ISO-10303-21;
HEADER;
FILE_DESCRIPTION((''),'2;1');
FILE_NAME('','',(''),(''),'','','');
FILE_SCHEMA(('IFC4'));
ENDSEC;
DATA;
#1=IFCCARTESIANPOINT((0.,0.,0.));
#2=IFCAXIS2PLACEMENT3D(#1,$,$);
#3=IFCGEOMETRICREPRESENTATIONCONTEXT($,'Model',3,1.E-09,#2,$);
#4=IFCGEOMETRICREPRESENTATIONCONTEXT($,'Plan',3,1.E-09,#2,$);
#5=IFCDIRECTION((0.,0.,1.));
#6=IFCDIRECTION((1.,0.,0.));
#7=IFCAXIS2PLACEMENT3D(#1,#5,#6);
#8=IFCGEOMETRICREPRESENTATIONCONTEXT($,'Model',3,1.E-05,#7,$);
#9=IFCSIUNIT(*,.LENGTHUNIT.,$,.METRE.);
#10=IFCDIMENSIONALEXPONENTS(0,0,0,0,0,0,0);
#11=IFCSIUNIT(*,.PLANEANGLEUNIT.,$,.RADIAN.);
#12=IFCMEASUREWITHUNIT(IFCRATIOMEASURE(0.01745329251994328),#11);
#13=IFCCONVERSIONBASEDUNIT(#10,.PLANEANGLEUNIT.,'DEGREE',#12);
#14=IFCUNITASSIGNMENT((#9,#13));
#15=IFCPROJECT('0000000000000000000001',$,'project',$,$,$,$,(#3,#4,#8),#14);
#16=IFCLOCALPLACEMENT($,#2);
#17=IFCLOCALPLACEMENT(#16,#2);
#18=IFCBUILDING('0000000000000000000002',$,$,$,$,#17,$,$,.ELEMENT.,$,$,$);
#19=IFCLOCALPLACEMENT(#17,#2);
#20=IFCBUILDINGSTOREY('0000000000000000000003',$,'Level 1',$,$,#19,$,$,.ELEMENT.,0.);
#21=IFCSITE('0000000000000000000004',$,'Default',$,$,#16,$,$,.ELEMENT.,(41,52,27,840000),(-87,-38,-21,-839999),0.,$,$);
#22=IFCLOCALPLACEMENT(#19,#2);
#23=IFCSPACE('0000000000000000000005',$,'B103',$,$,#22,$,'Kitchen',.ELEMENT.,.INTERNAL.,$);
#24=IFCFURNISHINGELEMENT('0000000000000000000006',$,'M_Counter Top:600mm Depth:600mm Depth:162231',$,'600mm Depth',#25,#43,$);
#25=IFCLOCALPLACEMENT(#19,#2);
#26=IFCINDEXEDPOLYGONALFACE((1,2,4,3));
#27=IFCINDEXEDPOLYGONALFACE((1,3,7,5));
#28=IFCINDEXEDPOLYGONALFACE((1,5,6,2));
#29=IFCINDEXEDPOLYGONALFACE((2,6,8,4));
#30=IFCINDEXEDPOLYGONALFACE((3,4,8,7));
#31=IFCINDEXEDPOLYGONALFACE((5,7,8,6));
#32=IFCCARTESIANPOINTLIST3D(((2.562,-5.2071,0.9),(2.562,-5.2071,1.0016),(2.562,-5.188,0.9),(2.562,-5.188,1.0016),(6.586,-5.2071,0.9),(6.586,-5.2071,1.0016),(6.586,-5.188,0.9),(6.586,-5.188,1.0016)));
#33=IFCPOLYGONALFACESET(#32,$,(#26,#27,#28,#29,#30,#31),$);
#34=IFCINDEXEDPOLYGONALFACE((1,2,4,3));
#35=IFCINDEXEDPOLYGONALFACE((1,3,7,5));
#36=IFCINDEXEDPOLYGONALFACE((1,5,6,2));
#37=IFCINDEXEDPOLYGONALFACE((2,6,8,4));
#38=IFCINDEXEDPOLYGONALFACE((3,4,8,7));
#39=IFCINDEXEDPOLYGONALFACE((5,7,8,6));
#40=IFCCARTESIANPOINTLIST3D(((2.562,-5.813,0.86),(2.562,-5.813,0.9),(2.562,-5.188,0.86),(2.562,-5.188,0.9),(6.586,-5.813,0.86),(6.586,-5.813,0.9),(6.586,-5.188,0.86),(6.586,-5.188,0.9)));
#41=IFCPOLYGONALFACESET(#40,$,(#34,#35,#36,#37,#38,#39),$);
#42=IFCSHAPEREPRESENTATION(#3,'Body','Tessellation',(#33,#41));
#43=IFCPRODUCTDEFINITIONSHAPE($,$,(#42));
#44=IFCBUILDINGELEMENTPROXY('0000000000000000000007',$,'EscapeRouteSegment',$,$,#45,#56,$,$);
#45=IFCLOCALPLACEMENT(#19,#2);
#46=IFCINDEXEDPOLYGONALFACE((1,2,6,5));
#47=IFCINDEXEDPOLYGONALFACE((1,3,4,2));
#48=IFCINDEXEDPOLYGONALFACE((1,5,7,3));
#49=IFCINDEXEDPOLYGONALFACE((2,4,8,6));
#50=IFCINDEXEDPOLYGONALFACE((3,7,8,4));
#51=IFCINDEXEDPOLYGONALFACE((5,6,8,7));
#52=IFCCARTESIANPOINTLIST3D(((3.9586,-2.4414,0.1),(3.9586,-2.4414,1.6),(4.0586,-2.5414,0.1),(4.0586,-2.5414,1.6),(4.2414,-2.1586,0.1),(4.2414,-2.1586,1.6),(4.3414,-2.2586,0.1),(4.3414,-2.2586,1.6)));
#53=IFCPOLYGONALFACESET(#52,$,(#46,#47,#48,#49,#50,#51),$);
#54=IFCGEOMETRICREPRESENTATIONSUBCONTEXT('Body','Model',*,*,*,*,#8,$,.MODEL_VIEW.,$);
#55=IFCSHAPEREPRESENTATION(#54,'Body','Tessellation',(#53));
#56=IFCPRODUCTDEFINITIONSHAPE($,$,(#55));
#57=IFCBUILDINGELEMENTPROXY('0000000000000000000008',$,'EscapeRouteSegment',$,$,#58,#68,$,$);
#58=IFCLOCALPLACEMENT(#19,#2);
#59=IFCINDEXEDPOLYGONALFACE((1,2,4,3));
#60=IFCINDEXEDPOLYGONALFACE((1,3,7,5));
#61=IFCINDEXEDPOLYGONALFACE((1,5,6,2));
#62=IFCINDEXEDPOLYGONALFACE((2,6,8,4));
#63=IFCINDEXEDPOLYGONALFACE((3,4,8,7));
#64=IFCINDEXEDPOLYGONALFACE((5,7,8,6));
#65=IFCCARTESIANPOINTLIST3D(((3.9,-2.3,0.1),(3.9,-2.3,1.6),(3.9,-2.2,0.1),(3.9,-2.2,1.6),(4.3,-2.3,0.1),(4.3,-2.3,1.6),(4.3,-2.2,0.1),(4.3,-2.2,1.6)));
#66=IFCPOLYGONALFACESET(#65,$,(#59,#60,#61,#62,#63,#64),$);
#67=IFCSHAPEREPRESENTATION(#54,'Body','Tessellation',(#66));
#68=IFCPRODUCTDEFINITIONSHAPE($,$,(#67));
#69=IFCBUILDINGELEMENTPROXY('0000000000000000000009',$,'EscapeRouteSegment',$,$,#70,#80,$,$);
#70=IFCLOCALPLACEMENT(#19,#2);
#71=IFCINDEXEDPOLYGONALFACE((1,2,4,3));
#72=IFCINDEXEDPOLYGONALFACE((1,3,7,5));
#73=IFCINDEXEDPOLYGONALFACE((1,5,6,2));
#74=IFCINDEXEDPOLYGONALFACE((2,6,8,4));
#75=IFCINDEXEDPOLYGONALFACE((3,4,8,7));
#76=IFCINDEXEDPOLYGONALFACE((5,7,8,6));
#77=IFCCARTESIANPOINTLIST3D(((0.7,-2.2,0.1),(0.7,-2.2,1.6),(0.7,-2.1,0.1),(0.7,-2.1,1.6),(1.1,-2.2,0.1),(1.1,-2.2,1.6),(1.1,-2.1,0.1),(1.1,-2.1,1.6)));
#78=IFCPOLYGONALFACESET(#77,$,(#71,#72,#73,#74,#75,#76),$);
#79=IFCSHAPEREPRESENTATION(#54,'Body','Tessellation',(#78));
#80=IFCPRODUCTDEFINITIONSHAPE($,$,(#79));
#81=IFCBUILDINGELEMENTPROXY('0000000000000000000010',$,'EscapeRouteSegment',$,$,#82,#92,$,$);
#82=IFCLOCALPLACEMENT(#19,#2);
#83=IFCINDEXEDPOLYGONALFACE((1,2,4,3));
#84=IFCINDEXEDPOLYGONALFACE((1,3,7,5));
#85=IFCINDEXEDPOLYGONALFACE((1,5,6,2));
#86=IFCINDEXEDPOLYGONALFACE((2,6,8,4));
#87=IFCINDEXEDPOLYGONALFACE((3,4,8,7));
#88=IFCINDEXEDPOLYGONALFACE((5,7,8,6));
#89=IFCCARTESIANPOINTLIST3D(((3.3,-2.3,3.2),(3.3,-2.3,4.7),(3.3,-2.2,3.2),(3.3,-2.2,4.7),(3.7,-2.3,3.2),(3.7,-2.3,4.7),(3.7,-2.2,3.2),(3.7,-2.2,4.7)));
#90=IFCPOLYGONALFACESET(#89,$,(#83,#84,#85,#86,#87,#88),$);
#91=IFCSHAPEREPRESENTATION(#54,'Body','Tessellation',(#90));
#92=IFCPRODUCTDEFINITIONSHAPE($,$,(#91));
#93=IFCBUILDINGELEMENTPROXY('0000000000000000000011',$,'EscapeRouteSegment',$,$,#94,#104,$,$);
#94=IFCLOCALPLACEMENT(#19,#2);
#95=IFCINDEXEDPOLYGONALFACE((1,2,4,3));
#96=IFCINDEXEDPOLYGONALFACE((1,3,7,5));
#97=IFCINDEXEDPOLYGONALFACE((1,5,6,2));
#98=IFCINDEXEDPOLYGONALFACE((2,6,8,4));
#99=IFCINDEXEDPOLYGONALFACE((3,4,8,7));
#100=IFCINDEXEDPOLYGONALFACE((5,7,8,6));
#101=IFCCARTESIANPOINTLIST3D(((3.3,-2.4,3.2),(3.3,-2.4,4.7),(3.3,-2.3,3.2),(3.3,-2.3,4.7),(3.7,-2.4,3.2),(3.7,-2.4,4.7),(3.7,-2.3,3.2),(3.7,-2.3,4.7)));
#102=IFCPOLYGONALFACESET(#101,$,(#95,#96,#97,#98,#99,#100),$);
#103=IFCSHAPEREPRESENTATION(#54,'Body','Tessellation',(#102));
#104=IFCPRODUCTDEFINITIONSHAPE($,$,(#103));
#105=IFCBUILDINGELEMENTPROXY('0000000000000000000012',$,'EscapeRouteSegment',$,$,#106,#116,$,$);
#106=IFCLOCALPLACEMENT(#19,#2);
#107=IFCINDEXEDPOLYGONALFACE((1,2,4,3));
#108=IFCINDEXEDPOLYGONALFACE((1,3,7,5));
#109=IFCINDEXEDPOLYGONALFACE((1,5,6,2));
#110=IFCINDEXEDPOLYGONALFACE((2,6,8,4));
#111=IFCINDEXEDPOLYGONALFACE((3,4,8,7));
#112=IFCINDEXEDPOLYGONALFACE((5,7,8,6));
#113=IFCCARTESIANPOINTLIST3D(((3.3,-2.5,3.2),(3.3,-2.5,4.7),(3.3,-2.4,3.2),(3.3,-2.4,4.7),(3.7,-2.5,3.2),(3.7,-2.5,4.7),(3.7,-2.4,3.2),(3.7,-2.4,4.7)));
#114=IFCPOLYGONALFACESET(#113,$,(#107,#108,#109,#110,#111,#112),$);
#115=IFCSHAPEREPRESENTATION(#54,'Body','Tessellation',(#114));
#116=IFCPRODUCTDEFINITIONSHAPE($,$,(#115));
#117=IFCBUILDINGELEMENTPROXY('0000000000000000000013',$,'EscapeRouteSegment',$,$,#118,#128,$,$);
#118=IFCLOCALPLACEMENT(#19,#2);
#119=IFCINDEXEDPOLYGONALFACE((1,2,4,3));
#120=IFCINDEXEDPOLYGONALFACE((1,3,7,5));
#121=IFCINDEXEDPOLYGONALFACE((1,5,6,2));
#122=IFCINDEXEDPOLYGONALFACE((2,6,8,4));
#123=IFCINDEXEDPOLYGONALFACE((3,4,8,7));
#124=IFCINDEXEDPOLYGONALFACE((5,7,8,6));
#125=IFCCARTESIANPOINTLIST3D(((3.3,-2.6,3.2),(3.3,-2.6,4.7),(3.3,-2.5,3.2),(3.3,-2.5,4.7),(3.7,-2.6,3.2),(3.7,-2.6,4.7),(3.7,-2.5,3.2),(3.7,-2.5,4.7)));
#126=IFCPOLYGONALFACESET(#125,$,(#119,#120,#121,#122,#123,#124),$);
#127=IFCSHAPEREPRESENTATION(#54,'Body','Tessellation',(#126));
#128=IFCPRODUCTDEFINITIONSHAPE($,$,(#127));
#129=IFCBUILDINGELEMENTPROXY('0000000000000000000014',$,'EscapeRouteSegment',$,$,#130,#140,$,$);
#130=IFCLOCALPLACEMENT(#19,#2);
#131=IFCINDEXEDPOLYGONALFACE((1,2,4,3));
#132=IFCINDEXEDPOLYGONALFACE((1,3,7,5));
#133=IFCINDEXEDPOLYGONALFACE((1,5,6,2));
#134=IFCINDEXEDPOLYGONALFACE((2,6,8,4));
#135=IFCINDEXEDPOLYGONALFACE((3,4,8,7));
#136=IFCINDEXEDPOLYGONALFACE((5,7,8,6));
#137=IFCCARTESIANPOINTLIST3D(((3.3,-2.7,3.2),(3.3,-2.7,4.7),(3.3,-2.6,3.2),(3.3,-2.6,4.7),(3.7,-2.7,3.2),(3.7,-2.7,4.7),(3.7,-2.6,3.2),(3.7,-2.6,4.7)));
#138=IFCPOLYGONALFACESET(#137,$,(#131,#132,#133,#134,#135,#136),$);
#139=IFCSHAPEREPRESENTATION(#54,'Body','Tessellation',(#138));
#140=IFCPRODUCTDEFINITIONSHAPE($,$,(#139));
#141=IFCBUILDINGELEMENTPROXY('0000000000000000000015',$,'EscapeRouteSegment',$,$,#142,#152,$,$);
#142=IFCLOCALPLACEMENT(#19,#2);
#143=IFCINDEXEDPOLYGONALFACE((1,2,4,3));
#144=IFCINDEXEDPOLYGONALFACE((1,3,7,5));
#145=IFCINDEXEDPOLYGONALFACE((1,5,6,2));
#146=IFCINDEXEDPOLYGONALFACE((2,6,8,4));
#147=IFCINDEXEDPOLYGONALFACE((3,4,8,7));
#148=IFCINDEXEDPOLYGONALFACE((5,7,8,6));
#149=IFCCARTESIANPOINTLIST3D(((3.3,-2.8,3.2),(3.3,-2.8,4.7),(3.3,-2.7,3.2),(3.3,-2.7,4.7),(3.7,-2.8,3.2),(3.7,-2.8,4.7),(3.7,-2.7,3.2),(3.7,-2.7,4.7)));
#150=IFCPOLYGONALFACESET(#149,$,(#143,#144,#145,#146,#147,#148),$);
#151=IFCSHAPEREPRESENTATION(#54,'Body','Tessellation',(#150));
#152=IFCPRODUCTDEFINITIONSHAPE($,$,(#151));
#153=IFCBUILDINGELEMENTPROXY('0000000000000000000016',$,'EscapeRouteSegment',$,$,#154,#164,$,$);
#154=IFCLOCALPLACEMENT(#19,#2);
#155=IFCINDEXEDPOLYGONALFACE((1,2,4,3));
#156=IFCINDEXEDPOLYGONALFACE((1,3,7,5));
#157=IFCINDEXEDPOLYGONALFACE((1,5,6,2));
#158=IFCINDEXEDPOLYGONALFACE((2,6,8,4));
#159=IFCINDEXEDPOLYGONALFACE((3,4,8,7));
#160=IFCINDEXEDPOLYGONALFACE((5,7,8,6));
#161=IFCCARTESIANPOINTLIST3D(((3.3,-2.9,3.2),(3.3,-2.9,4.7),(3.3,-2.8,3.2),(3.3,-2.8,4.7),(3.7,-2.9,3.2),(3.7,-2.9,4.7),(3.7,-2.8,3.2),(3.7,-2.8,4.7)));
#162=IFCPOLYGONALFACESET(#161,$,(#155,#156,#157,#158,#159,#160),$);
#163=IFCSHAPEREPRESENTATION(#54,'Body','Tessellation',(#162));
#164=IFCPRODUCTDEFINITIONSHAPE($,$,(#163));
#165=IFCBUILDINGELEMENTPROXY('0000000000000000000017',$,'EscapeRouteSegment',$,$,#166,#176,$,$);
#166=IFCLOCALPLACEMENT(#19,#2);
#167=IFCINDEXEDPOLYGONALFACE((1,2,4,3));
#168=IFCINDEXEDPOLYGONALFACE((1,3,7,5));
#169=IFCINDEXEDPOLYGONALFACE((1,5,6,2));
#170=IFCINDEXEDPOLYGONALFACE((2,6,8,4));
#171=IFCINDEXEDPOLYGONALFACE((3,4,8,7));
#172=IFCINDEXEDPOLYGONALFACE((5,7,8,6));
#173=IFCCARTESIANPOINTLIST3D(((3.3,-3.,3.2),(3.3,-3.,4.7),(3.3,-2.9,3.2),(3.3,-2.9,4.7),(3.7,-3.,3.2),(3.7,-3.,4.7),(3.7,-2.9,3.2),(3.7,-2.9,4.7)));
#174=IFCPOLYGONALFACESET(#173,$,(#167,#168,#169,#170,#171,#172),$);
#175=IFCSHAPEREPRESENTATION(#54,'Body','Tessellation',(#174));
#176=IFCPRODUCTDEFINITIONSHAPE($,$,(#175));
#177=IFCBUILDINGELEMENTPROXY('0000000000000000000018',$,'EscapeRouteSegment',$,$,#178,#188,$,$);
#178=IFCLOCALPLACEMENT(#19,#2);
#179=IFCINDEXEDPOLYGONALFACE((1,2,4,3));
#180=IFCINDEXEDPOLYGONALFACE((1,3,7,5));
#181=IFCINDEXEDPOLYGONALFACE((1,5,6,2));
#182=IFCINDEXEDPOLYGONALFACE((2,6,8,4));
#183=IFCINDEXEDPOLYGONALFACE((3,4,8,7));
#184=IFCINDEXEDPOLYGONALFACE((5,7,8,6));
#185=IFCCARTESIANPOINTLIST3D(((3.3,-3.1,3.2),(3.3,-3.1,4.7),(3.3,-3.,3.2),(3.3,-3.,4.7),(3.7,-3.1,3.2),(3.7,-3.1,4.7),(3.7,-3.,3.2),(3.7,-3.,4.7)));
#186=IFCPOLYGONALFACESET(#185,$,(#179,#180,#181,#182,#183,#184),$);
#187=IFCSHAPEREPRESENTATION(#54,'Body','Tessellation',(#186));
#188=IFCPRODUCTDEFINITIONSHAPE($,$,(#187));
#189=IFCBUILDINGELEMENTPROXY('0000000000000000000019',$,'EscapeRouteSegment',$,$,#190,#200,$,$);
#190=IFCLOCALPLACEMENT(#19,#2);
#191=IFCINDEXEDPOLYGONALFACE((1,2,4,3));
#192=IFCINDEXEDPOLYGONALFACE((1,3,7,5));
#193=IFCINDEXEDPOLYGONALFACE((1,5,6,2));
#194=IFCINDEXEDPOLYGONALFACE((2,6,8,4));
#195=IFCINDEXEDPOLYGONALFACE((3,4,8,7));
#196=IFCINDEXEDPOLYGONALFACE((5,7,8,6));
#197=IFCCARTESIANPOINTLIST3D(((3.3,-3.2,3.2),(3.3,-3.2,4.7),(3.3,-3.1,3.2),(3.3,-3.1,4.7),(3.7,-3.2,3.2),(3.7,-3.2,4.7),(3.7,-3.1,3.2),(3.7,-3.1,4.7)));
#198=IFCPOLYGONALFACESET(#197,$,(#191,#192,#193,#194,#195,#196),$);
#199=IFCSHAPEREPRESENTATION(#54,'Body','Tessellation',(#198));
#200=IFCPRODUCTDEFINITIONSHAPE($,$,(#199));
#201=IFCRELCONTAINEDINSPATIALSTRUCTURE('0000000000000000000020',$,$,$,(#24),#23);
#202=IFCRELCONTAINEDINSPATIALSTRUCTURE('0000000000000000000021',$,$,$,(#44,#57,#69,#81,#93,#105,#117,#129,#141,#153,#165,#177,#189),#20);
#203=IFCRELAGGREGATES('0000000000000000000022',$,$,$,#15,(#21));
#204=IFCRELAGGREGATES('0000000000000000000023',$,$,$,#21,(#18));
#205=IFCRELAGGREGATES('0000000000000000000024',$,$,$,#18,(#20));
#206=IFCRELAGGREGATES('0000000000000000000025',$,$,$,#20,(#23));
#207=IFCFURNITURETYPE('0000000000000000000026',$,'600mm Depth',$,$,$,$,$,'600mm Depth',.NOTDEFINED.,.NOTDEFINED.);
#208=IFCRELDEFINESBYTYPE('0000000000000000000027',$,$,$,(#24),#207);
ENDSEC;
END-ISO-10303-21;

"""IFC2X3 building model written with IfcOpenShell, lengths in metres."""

from ifc_helpers import new_model, entity, si_unit, converted_unit, frame, origin, origin_with_axes, origin_2d_with_axis, place, context, subcontext, project, spatial, polyline, rectangle, outline, extrude, source, transform, mapped, type_object, type_shapes, element, save


model = new_model("IFC2X3")

# Units and contexts
model_context_1 = context("Model", 3, precision=1e-09, world=origin())
plan_context = context("Plan", 3, precision=1e-09, world=origin())
model_context_2 = context("Model", 3, precision=1e-05, world=origin_with_axes())
body_context = subcontext(model_context_2, "Body", "Model", "MODEL_VIEW")
ifc_project = project(units=[si_unit("LENGTHUNIT", "METRE"), converted_unit("PLANEANGLEUNIT", "DEGREE", entity("IfcRatioMeasure", 0.01745329251994328), si_unit("PLANEANGLEUNIT", "RADIAN"), dimensions=[0, 0, 0, 0, 0, 0, 0])], contexts=[model_context_1, plan_context, model_context_2])

# Site, building, storey, space
site_placement = place(None, origin())
site = spatial("IfcSite", under=ifc_project, at=site_placement, Name="Default", CompositionType="ELEMENT", RefLatitude=(41, 52, 27, 840000), RefLongitude=(-87, -38, -21, -839999), RefElevation=0.0)
building_placement = place(site_placement, origin())
building = spatial("IfcBuilding", under=site, at=building_placement, CompositionType="ELEMENT")
storey_placement = place(building_placement, origin())
storey = spatial("IfcBuildingStorey", under=building, at=storey_placement, Name="Level 1", CompositionType="ELEMENT", Elevation=0.0)
space_placement = place(storey_placement, origin())
space = spatial("IfcSpace", under=storey, at=space_placement, Name="B103", LongName="Kitchen", CompositionType="ELEMENT", InteriorOrExteriorSpace="INTERNAL")

# Furnishing element
furniture_type = type_object("IfcFurnitureType", Name="600mm Depth", ElementType="600mm Depth", AssemblyPlace="NOTDEFINED")
shared_shape = source(origin(), model_context_1, "Body", "SweptSolid", [
    extrude(rectangle(XDim=0.0191, YDim=4.024, at=origin_2d_with_axis()), frame((0.8115, -0.0095, 0.9), z_axis=(0.0, 0.0, 1.0), x_axis=(0.0, -1.0, 0.0)), (0.0, 0.0, 1.0), 0.1016),
    extrude(rectangle(XDim=4.024, YDim=0.625, at=origin_2d_with_axis()), frame((0.8115, -0.3125, 0.86), z_axis=(0.0, 0.0, 1.0), x_axis=(-1.0, 0.0, 0.0)), (0.0, 0.0, 1.0), 0.04),
])
type_shapes(furniture_type, [shared_shape])
furnishing_placement = place(space_placement, frame((3.7625, -5.188, 0.0)))
element("IfcFurnishingElement", 1, at=furnishing_placement, inside=space, type_object=furniture_type, Name="M_Counter Top:600mm Depth:600mm Depth:162231", ObjectType="600mm Depth", context=model_context_1, shape_type="MappedRepresentation", body=[
    mapped(shared_shape, transform((0.0, 0.0, 0.0), scale=1.0)),
])

# Building element proxies
proxy_1_placement = place(storey_placement, frame((4.2, -2.4, 0.1), z_axis=(0.0, 0.0, 1.0), x_axis=(-0.707106, 0.707108, 0.0)))
element("IfcBuildingElementProxy", 2, at=proxy_1_placement, inside=storey, Name="EscapeRouteSegment", context=body_context, shape_type="SweptSolid", body=[
    extrude(outline(polyline([(0.0, -0.2), (0.0, 0.2), (0.1414, 0.2), (0.1414, -0.2), (0.0, -0.2)])), origin_with_axes(), (0.0, 0.0, 1.0), 1.5),
])
proxy_2_placement = place(storey_placement, frame((4.1, -2.3, 0.1), z_axis=(0.0, 0.0, 1.0), x_axis=(0.0, 1.0, 0.0)))
element("IfcBuildingElementProxy", 3, at=proxy_2_placement, inside=storey, Name="EscapeRouteSegment", context=body_context, shape_type="SweptSolid", body=[
    extrude(outline(polyline([(0.0, -0.2), (0.0, 0.2), (0.1, 0.2), (0.1, -0.2), (0.0, -0.2)])), origin_with_axes(), (0.0, 0.0, 1.0), 1.5),
])
for number, where, z_axis, x_axis, name in (
    (4, (0.9, -2.2, 0.1), (0.0, 0.0, 1.0), (0.0, 1.0, 0.0), "EscapeRouteSegment"),
):
    element("IfcBuildingElementProxy", number, at=place(storey_placement, frame(where, z_axis=z_axis, x_axis=x_axis)), inside=storey, Name=name, context=body_context, shape_type="SweptSolid", body=[
        extrude(outline(polyline([(0.0, -0.2), (0.0, 0.2), (0.1, 0.2), (0.1, -0.2), (0.0, -0.2)])), origin_with_axes(), (0.0, 0.0, 1.0), 1.5),
    ])
proxy_3_placement = place(storey_placement, frame((3.5, -2.2, 3.2), z_axis=(0.0, 0.0, 1.0), x_axis=(0.0, -1.0, 0.0)))
element("IfcBuildingElementProxy", 5, at=proxy_3_placement, inside=storey, Name="EscapeRouteSegment", context=body_context, shape_type="SweptSolid", body=[
    extrude(outline(polyline([(0.0, -0.2), (0.0, 0.2), (0.1, 0.2), (0.1, -0.2), (0.0, -0.2)])), origin_with_axes(), (0.0, 0.0, 1.0), 1.5),
])
proxy_4_placement = place(storey_placement, frame((3.5, -2.3, 3.2), z_axis=(0.0, 0.0, 1.0), x_axis=(0.0, -1.0, 0.0)))
element("IfcBuildingElementProxy", 6, at=proxy_4_placement, inside=storey, Name="EscapeRouteSegment", context=body_context, shape_type="SweptSolid", body=[
    extrude(outline(polyline([(0.0, -0.2), (0.0, 0.2), (0.1, 0.2), (0.1, -0.2), (0.0, -0.2)])), origin_with_axes(), (0.0, 0.0, 1.0), 1.5),
])
for number, where, z_axis, x_axis, name in (
    (7, (3.5, -2.4, 3.2), (0.0, 0.0, 1.0), (0.0, -1.0, 0.0), "EscapeRouteSegment"),
    (8, (3.5, -2.5, 3.2), (0.0, 0.0, 1.0), (0.0, -1.0, 0.0), "EscapeRouteSegment"),
):
    element("IfcBuildingElementProxy", number, at=place(storey_placement, frame(where, z_axis=z_axis, x_axis=x_axis)), inside=storey, Name=name, context=body_context, shape_type="SweptSolid", body=[
        extrude(outline(polyline([(0.0, -0.2), (0.0, 0.2), (0.1, 0.2), (0.1, -0.2), (0.0, -0.2)])), origin_with_axes(), (0.0, 0.0, 1.0), 1.5),
    ])
proxy_5_placement = place(storey_placement, frame((3.5, -2.6, 3.2), z_axis=(0.0, 0.0, 1.0), x_axis=(0.0, -1.0, 0.0)))
element("IfcBuildingElementProxy", 9, at=proxy_5_placement, inside=storey, Name="EscapeRouteSegment", context=body_context, shape_type="SweptSolid", body=[
    extrude(outline(polyline([(0.0, -0.2), (0.0, 0.2), (0.1, 0.2), (0.1, -0.2), (0.0, -0.2)])), origin_with_axes(), (0.0, 0.0, 1.0), 1.5),
])
proxy_6_placement = place(storey_placement, frame((3.5, -2.7, 3.2), z_axis=(0.0, 0.0, 1.0), x_axis=(0.0, -1.0, 0.0)))
element("IfcBuildingElementProxy", 10, at=proxy_6_placement, inside=storey, Name="EscapeRouteSegment", context=body_context, shape_type="SweptSolid", body=[
    extrude(outline(polyline([(0.0, -0.2), (0.0, 0.2), (0.1, 0.2), (0.1, -0.2), (0.0, -0.2)])), origin_with_axes(), (0.0, 0.0, 1.0), 1.5),
])
proxy_7_placement = place(storey_placement, frame((3.5, -2.8, 3.2), z_axis=(0.0, 0.0, 1.0), x_axis=(0.0, -1.0, 0.0)))
element("IfcBuildingElementProxy", 11, at=proxy_7_placement, inside=storey, Name="EscapeRouteSegment", context=body_context, shape_type="SweptSolid", body=[
    extrude(outline(polyline([(0.0, -0.2), (0.0, 0.2), (0.1, 0.2), (0.1, -0.2), (0.0, -0.2)])), origin_with_axes(), (0.0, 0.0, 1.0), 1.5),
])
for number, where, z_axis, x_axis, name in (
    (12, (3.5, -2.9, 3.2), (0.0, 0.0, 1.0), (0.0, -1.0, 0.0), "EscapeRouteSegment"),
    (13, (3.5, -3.0, 3.2), (0.0, 0.0, 1.0), (0.0, -1.0, 0.0), "EscapeRouteSegment"),
):
    element("IfcBuildingElementProxy", number, at=place(storey_placement, frame(where, z_axis=z_axis, x_axis=x_axis)), inside=storey, Name=name, context=body_context, shape_type="SweptSolid", body=[
        extrude(outline(polyline([(0.0, -0.2), (0.0, 0.2), (0.1, 0.2), (0.1, -0.2), (0.0, -0.2)])), origin_with_axes(), (0.0, 0.0, 1.0), 1.5),
    ])
proxy_8_placement = place(storey_placement, frame((3.5, -3.1, 3.2), z_axis=(0.0, 0.0, 1.0), x_axis=(0.0, -1.0, 0.0)))
element("IfcBuildingElementProxy", 14, at=proxy_8_placement, inside=storey, Name="EscapeRouteSegment", context=body_context, shape_type="SweptSolid", body=[
    extrude(outline(polyline([(0.0, -0.2), (0.0, 0.2), (0.1, 0.2), (0.1, -0.2), (0.0, -0.2)])), origin_with_axes(), (0.0, 0.0, 1.0), 1.5),
])

save(model, "model.ifc")
